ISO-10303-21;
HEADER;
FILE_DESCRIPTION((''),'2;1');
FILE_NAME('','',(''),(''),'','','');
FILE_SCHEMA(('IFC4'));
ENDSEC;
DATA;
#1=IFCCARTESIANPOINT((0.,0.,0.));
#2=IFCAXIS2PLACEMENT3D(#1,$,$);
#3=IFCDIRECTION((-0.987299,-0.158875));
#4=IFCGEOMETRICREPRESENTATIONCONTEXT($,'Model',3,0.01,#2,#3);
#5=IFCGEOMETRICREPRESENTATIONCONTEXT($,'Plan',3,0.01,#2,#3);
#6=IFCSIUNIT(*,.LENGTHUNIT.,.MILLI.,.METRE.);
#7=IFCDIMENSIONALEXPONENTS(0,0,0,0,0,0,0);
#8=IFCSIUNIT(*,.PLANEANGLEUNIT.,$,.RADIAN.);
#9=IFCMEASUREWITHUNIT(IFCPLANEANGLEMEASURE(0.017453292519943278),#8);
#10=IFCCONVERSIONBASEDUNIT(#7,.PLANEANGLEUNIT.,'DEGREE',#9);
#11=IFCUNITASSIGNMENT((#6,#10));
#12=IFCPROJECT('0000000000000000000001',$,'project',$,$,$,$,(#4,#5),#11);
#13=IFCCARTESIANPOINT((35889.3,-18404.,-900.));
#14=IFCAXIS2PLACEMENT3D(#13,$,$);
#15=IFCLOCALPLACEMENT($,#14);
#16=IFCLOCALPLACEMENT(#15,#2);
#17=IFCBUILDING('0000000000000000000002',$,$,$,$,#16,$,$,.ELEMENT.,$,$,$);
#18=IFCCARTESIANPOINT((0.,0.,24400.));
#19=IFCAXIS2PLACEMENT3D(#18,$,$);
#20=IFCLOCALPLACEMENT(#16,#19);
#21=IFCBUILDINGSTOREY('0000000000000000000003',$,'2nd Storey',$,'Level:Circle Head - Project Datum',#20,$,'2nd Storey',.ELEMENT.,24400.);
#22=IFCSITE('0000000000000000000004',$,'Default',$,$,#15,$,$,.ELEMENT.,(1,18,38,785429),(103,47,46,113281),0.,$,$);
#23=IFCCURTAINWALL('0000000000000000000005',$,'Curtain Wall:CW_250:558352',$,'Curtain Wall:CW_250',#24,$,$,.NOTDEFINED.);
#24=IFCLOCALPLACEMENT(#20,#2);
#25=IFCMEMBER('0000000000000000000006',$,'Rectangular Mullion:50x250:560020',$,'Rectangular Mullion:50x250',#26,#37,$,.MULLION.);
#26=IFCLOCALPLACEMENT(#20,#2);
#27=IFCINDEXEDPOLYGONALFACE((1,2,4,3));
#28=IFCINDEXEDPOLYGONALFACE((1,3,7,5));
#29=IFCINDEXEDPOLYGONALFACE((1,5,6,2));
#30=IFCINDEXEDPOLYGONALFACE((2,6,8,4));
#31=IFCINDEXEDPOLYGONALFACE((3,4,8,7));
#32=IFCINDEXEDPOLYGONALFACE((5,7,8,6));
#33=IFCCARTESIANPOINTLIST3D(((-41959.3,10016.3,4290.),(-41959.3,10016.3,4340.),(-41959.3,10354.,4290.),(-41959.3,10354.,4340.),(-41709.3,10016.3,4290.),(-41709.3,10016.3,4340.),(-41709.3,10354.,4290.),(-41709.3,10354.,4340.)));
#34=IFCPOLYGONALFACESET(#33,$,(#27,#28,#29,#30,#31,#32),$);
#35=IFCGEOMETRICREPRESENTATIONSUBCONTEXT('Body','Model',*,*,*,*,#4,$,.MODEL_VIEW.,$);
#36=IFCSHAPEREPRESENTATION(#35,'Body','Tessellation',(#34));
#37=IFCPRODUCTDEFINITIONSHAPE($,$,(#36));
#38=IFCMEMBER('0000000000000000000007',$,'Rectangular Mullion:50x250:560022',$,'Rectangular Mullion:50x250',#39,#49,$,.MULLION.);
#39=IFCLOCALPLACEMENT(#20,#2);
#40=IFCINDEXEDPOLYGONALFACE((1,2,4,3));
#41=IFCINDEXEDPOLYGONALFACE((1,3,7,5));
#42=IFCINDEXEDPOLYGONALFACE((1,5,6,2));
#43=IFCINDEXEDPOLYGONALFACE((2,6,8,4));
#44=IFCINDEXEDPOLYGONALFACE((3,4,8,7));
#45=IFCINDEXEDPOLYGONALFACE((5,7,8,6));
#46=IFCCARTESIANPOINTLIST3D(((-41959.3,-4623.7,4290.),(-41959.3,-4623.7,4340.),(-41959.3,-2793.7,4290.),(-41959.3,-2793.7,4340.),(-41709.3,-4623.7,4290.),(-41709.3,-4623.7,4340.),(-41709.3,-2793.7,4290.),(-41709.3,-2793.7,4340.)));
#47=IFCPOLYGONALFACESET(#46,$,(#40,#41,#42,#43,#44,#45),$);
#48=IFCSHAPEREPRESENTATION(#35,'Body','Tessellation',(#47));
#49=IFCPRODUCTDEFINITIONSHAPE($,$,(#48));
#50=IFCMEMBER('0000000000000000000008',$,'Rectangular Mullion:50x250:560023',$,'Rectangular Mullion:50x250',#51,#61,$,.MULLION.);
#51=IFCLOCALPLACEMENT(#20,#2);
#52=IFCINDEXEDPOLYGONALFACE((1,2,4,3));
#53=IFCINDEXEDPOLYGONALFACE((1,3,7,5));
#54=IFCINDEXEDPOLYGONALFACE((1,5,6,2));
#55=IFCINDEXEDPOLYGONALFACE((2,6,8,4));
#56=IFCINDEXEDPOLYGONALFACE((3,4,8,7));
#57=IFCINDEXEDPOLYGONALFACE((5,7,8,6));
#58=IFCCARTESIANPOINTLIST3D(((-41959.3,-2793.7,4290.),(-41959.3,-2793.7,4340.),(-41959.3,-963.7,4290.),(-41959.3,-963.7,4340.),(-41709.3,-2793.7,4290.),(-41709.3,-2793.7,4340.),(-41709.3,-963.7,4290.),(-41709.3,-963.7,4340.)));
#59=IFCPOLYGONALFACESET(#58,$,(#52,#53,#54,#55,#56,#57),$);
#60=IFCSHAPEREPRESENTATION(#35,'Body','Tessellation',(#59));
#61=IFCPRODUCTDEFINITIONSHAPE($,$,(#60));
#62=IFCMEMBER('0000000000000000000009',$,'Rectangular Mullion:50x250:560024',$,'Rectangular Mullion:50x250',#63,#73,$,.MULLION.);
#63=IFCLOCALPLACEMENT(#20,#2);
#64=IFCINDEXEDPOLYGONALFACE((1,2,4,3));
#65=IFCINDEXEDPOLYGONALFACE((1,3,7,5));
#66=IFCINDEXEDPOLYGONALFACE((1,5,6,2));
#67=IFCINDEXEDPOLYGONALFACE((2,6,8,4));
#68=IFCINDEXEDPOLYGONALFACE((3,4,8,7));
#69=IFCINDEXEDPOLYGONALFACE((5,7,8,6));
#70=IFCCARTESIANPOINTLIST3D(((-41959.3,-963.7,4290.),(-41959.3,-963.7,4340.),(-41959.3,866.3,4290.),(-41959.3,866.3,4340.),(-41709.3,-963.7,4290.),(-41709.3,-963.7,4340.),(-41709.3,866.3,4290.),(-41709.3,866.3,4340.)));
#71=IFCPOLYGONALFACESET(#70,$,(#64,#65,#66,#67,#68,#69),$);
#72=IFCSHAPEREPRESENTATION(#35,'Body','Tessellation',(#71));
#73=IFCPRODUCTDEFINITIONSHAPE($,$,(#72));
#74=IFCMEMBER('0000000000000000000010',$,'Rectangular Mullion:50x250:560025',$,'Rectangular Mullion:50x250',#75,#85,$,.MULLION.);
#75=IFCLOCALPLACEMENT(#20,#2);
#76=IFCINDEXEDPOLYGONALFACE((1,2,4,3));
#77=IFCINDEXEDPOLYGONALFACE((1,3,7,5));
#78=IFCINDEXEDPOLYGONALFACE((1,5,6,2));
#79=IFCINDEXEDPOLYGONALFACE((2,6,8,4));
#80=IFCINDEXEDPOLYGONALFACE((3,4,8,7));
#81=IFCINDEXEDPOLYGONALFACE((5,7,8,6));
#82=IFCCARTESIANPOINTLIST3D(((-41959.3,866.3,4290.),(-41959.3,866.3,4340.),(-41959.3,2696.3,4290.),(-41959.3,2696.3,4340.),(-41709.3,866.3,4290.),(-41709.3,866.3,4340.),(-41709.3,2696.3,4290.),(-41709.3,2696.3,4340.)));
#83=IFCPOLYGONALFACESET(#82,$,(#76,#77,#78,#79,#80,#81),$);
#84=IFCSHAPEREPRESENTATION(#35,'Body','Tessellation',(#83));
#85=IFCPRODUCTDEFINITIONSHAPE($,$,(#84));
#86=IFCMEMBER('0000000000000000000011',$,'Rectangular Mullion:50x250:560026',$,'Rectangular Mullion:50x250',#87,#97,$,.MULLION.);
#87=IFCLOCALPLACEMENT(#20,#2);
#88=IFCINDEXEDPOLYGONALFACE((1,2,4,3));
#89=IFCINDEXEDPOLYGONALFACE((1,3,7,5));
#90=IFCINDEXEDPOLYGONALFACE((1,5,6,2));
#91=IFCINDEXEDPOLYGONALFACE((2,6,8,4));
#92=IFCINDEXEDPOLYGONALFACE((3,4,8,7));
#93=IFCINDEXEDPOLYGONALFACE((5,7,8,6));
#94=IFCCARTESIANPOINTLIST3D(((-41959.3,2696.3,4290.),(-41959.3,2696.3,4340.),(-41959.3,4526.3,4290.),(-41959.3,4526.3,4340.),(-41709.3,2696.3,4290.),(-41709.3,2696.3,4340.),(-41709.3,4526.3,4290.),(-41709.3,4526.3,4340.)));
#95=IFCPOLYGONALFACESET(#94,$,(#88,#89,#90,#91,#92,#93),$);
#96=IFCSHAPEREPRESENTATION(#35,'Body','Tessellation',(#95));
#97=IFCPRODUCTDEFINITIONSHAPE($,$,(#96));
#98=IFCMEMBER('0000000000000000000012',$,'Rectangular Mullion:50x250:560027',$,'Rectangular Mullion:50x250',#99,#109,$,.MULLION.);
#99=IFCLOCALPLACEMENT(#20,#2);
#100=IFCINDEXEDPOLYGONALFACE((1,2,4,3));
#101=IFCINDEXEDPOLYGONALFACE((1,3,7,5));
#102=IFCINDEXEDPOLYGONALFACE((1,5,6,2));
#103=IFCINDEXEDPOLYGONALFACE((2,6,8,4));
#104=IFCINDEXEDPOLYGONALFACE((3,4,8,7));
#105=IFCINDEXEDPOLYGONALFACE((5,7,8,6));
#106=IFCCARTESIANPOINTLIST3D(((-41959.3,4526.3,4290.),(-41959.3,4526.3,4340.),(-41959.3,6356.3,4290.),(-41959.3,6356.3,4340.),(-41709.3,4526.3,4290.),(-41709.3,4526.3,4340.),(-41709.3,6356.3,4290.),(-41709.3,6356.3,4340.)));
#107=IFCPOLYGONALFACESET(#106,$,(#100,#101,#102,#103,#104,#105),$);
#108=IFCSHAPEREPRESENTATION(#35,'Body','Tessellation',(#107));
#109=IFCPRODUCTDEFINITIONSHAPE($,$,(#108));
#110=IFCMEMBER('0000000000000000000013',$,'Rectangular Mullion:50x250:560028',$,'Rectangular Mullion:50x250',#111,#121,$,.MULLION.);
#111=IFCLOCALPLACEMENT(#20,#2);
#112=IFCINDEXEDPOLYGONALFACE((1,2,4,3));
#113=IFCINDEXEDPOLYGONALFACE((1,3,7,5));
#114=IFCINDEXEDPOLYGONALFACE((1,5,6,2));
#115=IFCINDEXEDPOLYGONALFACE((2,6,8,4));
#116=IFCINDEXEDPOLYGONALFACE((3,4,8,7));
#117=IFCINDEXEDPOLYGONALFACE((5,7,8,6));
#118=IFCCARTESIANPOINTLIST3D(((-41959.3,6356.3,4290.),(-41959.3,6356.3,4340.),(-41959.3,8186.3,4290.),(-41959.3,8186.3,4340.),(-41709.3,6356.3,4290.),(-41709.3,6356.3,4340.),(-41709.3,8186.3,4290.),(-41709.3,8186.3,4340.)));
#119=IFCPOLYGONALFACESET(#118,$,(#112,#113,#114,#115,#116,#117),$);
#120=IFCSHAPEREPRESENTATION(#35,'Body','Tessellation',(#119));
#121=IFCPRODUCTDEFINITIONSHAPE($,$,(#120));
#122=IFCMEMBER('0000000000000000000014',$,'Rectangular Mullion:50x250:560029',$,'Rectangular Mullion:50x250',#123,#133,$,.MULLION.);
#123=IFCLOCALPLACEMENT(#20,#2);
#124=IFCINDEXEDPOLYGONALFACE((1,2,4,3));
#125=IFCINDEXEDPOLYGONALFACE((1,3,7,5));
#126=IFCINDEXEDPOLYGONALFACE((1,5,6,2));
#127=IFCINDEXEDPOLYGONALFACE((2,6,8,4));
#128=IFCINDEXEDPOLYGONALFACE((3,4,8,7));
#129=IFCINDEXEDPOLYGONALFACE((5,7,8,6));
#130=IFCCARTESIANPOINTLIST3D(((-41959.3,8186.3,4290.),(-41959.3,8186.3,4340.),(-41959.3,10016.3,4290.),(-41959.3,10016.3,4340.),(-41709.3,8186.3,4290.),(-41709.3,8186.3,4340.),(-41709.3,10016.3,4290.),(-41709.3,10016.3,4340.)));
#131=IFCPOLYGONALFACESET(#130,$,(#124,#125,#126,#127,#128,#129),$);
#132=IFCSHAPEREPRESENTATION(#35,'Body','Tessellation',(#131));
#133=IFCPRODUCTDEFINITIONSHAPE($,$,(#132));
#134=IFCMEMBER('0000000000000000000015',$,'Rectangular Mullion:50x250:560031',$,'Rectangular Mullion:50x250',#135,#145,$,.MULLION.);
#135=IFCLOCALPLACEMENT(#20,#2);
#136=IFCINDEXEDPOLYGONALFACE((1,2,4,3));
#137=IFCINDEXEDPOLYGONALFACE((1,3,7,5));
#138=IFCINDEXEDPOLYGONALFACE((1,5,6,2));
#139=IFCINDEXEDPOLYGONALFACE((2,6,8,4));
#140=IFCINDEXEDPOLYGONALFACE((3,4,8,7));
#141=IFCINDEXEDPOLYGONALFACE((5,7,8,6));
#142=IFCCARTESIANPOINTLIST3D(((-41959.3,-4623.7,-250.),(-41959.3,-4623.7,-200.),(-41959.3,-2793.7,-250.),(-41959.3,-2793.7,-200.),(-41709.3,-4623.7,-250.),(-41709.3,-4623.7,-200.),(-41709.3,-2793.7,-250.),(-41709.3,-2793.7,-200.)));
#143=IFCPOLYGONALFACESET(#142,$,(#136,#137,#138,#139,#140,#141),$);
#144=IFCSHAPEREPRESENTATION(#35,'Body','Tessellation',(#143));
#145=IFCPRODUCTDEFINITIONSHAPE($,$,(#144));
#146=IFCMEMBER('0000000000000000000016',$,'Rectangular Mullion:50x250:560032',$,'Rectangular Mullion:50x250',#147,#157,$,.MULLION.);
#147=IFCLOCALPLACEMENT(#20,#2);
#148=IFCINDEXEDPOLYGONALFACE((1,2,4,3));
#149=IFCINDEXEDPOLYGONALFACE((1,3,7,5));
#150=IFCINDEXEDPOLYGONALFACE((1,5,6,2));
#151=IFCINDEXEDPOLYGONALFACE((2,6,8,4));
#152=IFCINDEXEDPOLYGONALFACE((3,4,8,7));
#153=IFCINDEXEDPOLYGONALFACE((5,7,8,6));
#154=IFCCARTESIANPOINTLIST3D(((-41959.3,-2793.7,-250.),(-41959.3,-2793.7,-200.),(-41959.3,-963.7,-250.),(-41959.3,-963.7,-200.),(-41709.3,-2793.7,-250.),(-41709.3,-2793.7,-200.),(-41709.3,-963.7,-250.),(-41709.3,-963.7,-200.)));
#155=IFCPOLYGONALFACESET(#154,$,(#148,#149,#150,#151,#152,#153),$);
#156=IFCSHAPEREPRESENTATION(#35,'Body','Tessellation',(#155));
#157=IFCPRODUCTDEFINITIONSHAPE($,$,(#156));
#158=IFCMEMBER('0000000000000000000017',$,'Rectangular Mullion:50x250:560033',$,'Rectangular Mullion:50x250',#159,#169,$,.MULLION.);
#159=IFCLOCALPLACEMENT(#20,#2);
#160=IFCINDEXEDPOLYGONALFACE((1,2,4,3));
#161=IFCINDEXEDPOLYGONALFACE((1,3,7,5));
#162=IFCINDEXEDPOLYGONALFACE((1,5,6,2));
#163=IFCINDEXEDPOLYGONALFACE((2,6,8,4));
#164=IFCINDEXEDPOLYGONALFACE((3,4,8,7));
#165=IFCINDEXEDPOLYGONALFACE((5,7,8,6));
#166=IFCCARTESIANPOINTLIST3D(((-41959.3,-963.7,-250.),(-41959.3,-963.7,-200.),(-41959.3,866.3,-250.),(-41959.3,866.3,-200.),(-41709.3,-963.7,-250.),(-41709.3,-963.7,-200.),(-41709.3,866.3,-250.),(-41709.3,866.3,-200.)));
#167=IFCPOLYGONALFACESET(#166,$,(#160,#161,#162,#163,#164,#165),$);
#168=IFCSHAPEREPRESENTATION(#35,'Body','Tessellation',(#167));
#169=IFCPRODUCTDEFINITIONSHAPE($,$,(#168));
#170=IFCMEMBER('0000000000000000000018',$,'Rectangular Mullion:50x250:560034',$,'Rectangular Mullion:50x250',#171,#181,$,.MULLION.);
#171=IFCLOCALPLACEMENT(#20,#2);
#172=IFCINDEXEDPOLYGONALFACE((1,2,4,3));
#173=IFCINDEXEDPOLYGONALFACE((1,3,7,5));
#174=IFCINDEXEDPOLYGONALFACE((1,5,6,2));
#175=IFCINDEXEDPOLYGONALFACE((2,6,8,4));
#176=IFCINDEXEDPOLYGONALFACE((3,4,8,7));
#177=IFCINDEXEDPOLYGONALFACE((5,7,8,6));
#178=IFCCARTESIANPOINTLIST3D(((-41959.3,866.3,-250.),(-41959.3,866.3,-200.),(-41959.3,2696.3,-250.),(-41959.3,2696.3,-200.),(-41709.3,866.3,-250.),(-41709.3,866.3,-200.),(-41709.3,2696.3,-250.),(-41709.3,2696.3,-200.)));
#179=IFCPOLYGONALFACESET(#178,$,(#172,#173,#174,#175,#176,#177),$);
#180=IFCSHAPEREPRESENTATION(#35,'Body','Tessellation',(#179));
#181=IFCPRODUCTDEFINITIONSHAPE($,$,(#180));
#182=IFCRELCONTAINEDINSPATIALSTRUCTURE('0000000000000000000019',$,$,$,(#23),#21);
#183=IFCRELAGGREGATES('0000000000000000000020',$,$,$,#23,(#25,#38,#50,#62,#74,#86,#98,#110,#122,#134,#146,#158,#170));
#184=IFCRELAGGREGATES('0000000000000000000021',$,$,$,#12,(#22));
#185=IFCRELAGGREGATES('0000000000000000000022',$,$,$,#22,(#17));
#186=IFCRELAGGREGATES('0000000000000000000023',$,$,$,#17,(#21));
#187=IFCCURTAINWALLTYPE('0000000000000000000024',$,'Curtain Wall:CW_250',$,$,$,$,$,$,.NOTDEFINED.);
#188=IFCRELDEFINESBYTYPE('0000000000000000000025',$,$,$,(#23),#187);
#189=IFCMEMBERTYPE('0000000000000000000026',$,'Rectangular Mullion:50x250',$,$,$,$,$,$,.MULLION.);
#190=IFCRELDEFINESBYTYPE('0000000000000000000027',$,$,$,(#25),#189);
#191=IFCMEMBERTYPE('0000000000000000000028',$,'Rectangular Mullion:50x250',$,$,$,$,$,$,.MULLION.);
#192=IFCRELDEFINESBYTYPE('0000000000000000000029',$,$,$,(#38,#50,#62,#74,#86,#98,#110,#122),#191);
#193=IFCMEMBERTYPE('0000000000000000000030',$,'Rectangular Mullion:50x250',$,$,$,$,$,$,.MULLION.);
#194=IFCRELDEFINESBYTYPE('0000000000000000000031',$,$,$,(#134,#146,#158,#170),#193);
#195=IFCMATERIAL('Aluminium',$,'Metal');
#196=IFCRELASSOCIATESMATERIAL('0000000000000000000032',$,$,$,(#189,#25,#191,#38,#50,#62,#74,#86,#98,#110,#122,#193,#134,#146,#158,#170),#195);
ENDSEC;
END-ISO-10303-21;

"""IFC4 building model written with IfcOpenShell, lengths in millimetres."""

from ifc_helpers import new_model, entity, si_unit, converted_unit, direction, frame, origin, place, context, subcontext, project, spatial, indexed_curve, outline, extrude, source, transform, mapped, material, type_object, type_shapes, element, aggregate, save


model = new_model("IFC4")

# Units and contexts
model_context = context("Model", 3, precision=0.01, world=origin(), true_north=direction((-0.987299, -0.158875)))
plan_context = context("Plan", 3, precision=0.01, world=origin(), true_north=direction((-0.987299, -0.158875)))
body_context = subcontext(model_context, "Body", "Model", "MODEL_VIEW")
ifc_project = project(units=[si_unit("LENGTHUNIT", "METRE", prefix="MILLI"), converted_unit("PLANEANGLEUNIT", "DEGREE", entity("IfcPlaneAngleMeasure", 0.017453292519943278), si_unit("PLANEANGLEUNIT", "RADIAN"), dimensions=[0, 0, 0, 0, 0, 0, 0])], contexts=[model_context, plan_context])

# Site, building, storey
site_placement = place(None, frame((35889.3, -18404.0, -900.0)))
site = spatial("IfcSite", under=ifc_project, at=site_placement, Name="Default", CompositionType="ELEMENT", RefLatitude=(1, 18, 38, 785429), RefLongitude=(103, 47, 46, 113281), RefElevation=0.0)
building_placement = place(site_placement, origin())
building = spatial("IfcBuilding", under=site, at=building_placement, CompositionType="ELEMENT")
storey_placement = place(building_placement, frame((0.0, 0.0, 24400.0)))
storey = spatial("IfcBuildingStorey", under=building, at=storey_placement, Name="2nd Storey", ObjectType="Level:Circle Head - Project Datum", LongName="2nd Storey", CompositionType="ELEMENT", Elevation=24400.0)

# Curtain wall, members
curtain_wall_type = type_object("IfcCurtainWallType", Name="Curtain Wall:CW_250", PredefinedType="NOTDEFINED")
curtain_wall_1_placement = place(storey_placement, frame((0.0, 0.0, -24400.0)))
curtain_wall_1 = element("IfcCurtainWall", 1, at=curtain_wall_1_placement, inside=storey, type_object=curtain_wall_type, Name="Curtain Wall:CW_250:558352", ObjectType="Curtain Wall:CW_250", PredefinedType="NOTDEFINED")
ifc_material_1 = material(Name="Aluminium", Category="Metal")
member_type_1 = type_object("IfcMemberType", Name="Rectangular Mullion:50x250", PredefinedType="MULLION", material=ifc_material_1)
shared_shape_1 = source(origin(), body_context, "Body", "SweptSolid", [
    extrude(outline(indexed_curve([(-25.0, -125.0), (25.0, -125.0), (25.0, 125.0), (-25.0, 125.0), (-25.0, -125.0)], self_intersect=False)), frame((-25.0, -125.0, -337.7), z_axis=(0.0, 0.0, 1.0), x_axis=(-1.0, 0.0, 0.0)), (0.0, 0.0, 1.0), 337.7),
])
type_shapes(member_type_1, [shared_shape_1])
member_1_placement = place(curtain_wall_1_placement, frame((-41709.3, 10354.0, 28740.0), z_axis=(0.0, 1.0, 0.0), x_axis=(0.0, 0.0, 1.0)))
member_1 = element("IfcMember", 2, at=member_1_placement, type_object=member_type_1, material=ifc_material_1, Name="Rectangular Mullion:50x250:560020", ObjectType="Rectangular Mullion:50x250", PredefinedType="MULLION", context=body_context, shape_type="MappedRepresentation", body=[
    mapped(shared_shape_1, transform((0.0, 0.0, 0.0), scale=1.0)),
])
member_type_2 = type_object("IfcMemberType", Name="Rectangular Mullion:50x250", PredefinedType="MULLION", material=ifc_material_1)
shared_shape_2 = source(origin(), body_context, "Body", "SweptSolid", [
    extrude(outline(indexed_curve([(-25.0, -125.0), (25.0, -125.0), (25.0, 125.0), (-25.0, 125.0), (-25.0, -125.0)], self_intersect=False)), frame((-25.0, -125.0, -1830.0), z_axis=(0.0, 0.0, 1.0), x_axis=(-1.0, 0.0, 0.0)), (0.0, 0.0, 1.0), 1830.0),
])
type_shapes(member_type_2, [shared_shape_2])
member_2_placement = place(curtain_wall_1_placement, frame((-41709.3, -2793.7, 28740.0), z_axis=(0.0, 1.0, 0.0), x_axis=(0.0, 0.0, 1.0)))
member_2 = element("IfcMember", 3, at=member_2_placement, type_object=member_type_2, material=ifc_material_1, Name="Rectangular Mullion:50x250:560022", ObjectType="Rectangular Mullion:50x250", PredefinedType="MULLION", context=body_context, shape_type="MappedRepresentation", body=[
    mapped(shared_shape_2, transform((0.0, 0.0, 0.0), scale=1.0)),
])
member_3_placement = place(curtain_wall_1_placement, frame((-41709.3, -963.7, 28740.0), z_axis=(0.0, 1.0, 0.0), x_axis=(0.0, 0.0, 1.0)))
member_3 = element("IfcMember", 4, at=member_3_placement, type_object=member_type_2, material=ifc_material_1, Name="Rectangular Mullion:50x250:560023", ObjectType="Rectangular Mullion:50x250", PredefinedType="MULLION", context=body_context, shape_type="MappedRepresentation", body=[
    mapped(shared_shape_2, transform((0.0, 0.0, 0.0), scale=1.0)),
])
member_4_placement = place(curtain_wall_1_placement, frame((-41709.3, 866.3, 28740.0), z_axis=(0.0, 1.0, 0.0), x_axis=(0.0, 0.0, 1.0)))
member_4 = element("IfcMember", 5, at=member_4_placement, type_object=member_type_2, material=ifc_material_1, Name="Rectangular Mullion:50x250:560024", ObjectType="Rectangular Mullion:50x250", PredefinedType="MULLION", context=body_context, shape_type="MappedRepresentation", body=[
    mapped(shared_shape_2, transform((0.0, 0.0, 0.0), scale=1.0)),
])
member_5_placement = place(curtain_wall_1_placement, frame((-41709.3, 2696.3, 28740.0), z_axis=(0.0, 1.0, 0.0), x_axis=(0.0, 0.0, 1.0)))
member_5 = element("IfcMember", 6, at=member_5_placement, type_object=member_type_2, material=ifc_material_1, Name="Rectangular Mullion:50x250:560025", ObjectType="Rectangular Mullion:50x250", PredefinedType="MULLION", context=body_context, shape_type="MappedRepresentation", body=[
    mapped(shared_shape_2, transform((0.0, 0.0, 0.0), scale=1.0)),
])
member_6_placement = place(curtain_wall_1_placement, frame((-41709.3, 4526.3, 28740.0), z_axis=(0.0, 1.0, 0.0), x_axis=(0.0, 0.0, 1.0)))
member_6 = element("IfcMember", 7, at=member_6_placement, type_object=member_type_2, material=ifc_material_1, Name="Rectangular Mullion:50x250:560026", ObjectType="Rectangular Mullion:50x250", PredefinedType="MULLION", context=body_context, shape_type="MappedRepresentation", body=[
    mapped(shared_shape_2, transform((0.0, 0.0, 0.0), scale=1.0)),
])
member_7_placement = place(curtain_wall_1_placement, frame((-41709.3, 6356.3, 28740.0), z_axis=(0.0, 1.0, 0.0), x_axis=(0.0, 0.0, 1.0)))
member_7 = element("IfcMember", 8, at=member_7_placement, type_object=member_type_2, material=ifc_material_1, Name="Rectangular Mullion:50x250:560027", ObjectType="Rectangular Mullion:50x250", PredefinedType="MULLION", context=body_context, shape_type="MappedRepresentation", body=[
    mapped(shared_shape_2, transform((0.0, 0.0, 0.0), scale=1.0)),
])
member_8_placement = place(curtain_wall_1_placement, frame((-41709.3, 8186.3, 28740.0), z_axis=(0.0, 1.0, 0.0), x_axis=(0.0, 0.0, 1.0)))
member_8 = element("IfcMember", 9, at=member_8_placement, type_object=member_type_2, material=ifc_material_1, Name="Rectangular Mullion:50x250:560028", ObjectType="Rectangular Mullion:50x250", PredefinedType="MULLION", context=body_context, shape_type="MappedRepresentation", body=[
    mapped(shared_shape_2, transform((0.0, 0.0, 0.0), scale=1.0)),
])
member_9_placement = place(curtain_wall_1_placement, frame((-41709.3, 10016.3, 28740.0), z_axis=(0.0, 1.0, 0.0), x_axis=(0.0, 0.0, 1.0)))
member_9 = element("IfcMember", 10, at=member_9_placement, type_object=member_type_2, material=ifc_material_1, Name="Rectangular Mullion:50x250:560029", ObjectType="Rectangular Mullion:50x250", PredefinedType="MULLION", context=body_context, shape_type="MappedRepresentation", body=[
    mapped(shared_shape_2, transform((0.0, 0.0, 0.0), scale=1.0)),
])
member_type_3 = type_object("IfcMemberType", Name="Rectangular Mullion:50x250", PredefinedType="MULLION", material=ifc_material_1)
shared_shape_3 = source(origin(), body_context, "Body", "SweptSolid", [
    extrude(outline(indexed_curve([(-25.0, -125.0), (25.0, -125.0), (25.0, 125.0), (-25.0, 125.0), (-25.0, -125.0)], self_intersect=False)), frame((-25.0, -125.0, -1830.0), z_axis=(0.0, 0.0, 1.0), x_axis=(-1.0, 0.0, 0.0)), (0.0, 0.0, 1.0), 1830.0),
])
type_shapes(member_type_3, [shared_shape_3])
member_10_placement = place(curtain_wall_1_placement, frame((-41709.3, -4623.7, 24150.0), z_axis=(0.0, -1.0, 0.0), x_axis=(0.0, 0.0, -1.0)))
member_10 = element("IfcMember", 11, at=member_10_placement, type_object=member_type_3, material=ifc_material_1, Name="Rectangular Mullion:50x250:560031", ObjectType="Rectangular Mullion:50x250", PredefinedType="MULLION", context=body_context, shape_type="MappedRepresentation", body=[
    mapped(shared_shape_3, transform((0.0, 0.0, 0.0), scale=1.0)),
])
member_11_placement = place(curtain_wall_1_placement, frame((-41709.3, -2793.7, 24150.0), z_axis=(0.0, -1.0, 0.0), x_axis=(0.0, 0.0, -1.0)))
member_11 = element("IfcMember", 12, at=member_11_placement, type_object=member_type_3, material=ifc_material_1, Name="Rectangular Mullion:50x250:560032", ObjectType="Rectangular Mullion:50x250", PredefinedType="MULLION", context=body_context, shape_type="MappedRepresentation", body=[
    mapped(shared_shape_3, transform((0.0, 0.0, 0.0), scale=1.0)),
])
member_12_placement = place(curtain_wall_1_placement, frame((-41709.3, -963.7, 24150.0), z_axis=(0.0, -1.0, 0.0), x_axis=(0.0, 0.0, -1.0)))
member_12 = element("IfcMember", 13, at=member_12_placement, type_object=member_type_3, material=ifc_material_1, Name="Rectangular Mullion:50x250:560033", ObjectType="Rectangular Mullion:50x250", PredefinedType="MULLION", context=body_context, shape_type="MappedRepresentation", body=[
    mapped(shared_shape_3, transform((0.0, 0.0, 0.0), scale=1.0)),
])
member_13_placement = place(curtain_wall_1_placement, frame((-41709.3, 866.3, 24150.0), z_axis=(0.0, -1.0, 0.0), x_axis=(0.0, 0.0, -1.0)))
member_13 = element("IfcMember", 14, at=member_13_placement, type_object=member_type_3, material=ifc_material_1, Name="Rectangular Mullion:50x250:560034", ObjectType="Rectangular Mullion:50x250", PredefinedType="MULLION", context=body_context, shape_type="MappedRepresentation", body=[
    mapped(shared_shape_3, transform((0.0, 0.0, 0.0), scale=1.0)),
])

aggregate(curtain_wall_1, [member_1, member_2, member_3, member_4, member_5, member_6, member_7, member_8, member_9, member_10, member_11, member_12, member_13])

save(model, "model.ifc")
